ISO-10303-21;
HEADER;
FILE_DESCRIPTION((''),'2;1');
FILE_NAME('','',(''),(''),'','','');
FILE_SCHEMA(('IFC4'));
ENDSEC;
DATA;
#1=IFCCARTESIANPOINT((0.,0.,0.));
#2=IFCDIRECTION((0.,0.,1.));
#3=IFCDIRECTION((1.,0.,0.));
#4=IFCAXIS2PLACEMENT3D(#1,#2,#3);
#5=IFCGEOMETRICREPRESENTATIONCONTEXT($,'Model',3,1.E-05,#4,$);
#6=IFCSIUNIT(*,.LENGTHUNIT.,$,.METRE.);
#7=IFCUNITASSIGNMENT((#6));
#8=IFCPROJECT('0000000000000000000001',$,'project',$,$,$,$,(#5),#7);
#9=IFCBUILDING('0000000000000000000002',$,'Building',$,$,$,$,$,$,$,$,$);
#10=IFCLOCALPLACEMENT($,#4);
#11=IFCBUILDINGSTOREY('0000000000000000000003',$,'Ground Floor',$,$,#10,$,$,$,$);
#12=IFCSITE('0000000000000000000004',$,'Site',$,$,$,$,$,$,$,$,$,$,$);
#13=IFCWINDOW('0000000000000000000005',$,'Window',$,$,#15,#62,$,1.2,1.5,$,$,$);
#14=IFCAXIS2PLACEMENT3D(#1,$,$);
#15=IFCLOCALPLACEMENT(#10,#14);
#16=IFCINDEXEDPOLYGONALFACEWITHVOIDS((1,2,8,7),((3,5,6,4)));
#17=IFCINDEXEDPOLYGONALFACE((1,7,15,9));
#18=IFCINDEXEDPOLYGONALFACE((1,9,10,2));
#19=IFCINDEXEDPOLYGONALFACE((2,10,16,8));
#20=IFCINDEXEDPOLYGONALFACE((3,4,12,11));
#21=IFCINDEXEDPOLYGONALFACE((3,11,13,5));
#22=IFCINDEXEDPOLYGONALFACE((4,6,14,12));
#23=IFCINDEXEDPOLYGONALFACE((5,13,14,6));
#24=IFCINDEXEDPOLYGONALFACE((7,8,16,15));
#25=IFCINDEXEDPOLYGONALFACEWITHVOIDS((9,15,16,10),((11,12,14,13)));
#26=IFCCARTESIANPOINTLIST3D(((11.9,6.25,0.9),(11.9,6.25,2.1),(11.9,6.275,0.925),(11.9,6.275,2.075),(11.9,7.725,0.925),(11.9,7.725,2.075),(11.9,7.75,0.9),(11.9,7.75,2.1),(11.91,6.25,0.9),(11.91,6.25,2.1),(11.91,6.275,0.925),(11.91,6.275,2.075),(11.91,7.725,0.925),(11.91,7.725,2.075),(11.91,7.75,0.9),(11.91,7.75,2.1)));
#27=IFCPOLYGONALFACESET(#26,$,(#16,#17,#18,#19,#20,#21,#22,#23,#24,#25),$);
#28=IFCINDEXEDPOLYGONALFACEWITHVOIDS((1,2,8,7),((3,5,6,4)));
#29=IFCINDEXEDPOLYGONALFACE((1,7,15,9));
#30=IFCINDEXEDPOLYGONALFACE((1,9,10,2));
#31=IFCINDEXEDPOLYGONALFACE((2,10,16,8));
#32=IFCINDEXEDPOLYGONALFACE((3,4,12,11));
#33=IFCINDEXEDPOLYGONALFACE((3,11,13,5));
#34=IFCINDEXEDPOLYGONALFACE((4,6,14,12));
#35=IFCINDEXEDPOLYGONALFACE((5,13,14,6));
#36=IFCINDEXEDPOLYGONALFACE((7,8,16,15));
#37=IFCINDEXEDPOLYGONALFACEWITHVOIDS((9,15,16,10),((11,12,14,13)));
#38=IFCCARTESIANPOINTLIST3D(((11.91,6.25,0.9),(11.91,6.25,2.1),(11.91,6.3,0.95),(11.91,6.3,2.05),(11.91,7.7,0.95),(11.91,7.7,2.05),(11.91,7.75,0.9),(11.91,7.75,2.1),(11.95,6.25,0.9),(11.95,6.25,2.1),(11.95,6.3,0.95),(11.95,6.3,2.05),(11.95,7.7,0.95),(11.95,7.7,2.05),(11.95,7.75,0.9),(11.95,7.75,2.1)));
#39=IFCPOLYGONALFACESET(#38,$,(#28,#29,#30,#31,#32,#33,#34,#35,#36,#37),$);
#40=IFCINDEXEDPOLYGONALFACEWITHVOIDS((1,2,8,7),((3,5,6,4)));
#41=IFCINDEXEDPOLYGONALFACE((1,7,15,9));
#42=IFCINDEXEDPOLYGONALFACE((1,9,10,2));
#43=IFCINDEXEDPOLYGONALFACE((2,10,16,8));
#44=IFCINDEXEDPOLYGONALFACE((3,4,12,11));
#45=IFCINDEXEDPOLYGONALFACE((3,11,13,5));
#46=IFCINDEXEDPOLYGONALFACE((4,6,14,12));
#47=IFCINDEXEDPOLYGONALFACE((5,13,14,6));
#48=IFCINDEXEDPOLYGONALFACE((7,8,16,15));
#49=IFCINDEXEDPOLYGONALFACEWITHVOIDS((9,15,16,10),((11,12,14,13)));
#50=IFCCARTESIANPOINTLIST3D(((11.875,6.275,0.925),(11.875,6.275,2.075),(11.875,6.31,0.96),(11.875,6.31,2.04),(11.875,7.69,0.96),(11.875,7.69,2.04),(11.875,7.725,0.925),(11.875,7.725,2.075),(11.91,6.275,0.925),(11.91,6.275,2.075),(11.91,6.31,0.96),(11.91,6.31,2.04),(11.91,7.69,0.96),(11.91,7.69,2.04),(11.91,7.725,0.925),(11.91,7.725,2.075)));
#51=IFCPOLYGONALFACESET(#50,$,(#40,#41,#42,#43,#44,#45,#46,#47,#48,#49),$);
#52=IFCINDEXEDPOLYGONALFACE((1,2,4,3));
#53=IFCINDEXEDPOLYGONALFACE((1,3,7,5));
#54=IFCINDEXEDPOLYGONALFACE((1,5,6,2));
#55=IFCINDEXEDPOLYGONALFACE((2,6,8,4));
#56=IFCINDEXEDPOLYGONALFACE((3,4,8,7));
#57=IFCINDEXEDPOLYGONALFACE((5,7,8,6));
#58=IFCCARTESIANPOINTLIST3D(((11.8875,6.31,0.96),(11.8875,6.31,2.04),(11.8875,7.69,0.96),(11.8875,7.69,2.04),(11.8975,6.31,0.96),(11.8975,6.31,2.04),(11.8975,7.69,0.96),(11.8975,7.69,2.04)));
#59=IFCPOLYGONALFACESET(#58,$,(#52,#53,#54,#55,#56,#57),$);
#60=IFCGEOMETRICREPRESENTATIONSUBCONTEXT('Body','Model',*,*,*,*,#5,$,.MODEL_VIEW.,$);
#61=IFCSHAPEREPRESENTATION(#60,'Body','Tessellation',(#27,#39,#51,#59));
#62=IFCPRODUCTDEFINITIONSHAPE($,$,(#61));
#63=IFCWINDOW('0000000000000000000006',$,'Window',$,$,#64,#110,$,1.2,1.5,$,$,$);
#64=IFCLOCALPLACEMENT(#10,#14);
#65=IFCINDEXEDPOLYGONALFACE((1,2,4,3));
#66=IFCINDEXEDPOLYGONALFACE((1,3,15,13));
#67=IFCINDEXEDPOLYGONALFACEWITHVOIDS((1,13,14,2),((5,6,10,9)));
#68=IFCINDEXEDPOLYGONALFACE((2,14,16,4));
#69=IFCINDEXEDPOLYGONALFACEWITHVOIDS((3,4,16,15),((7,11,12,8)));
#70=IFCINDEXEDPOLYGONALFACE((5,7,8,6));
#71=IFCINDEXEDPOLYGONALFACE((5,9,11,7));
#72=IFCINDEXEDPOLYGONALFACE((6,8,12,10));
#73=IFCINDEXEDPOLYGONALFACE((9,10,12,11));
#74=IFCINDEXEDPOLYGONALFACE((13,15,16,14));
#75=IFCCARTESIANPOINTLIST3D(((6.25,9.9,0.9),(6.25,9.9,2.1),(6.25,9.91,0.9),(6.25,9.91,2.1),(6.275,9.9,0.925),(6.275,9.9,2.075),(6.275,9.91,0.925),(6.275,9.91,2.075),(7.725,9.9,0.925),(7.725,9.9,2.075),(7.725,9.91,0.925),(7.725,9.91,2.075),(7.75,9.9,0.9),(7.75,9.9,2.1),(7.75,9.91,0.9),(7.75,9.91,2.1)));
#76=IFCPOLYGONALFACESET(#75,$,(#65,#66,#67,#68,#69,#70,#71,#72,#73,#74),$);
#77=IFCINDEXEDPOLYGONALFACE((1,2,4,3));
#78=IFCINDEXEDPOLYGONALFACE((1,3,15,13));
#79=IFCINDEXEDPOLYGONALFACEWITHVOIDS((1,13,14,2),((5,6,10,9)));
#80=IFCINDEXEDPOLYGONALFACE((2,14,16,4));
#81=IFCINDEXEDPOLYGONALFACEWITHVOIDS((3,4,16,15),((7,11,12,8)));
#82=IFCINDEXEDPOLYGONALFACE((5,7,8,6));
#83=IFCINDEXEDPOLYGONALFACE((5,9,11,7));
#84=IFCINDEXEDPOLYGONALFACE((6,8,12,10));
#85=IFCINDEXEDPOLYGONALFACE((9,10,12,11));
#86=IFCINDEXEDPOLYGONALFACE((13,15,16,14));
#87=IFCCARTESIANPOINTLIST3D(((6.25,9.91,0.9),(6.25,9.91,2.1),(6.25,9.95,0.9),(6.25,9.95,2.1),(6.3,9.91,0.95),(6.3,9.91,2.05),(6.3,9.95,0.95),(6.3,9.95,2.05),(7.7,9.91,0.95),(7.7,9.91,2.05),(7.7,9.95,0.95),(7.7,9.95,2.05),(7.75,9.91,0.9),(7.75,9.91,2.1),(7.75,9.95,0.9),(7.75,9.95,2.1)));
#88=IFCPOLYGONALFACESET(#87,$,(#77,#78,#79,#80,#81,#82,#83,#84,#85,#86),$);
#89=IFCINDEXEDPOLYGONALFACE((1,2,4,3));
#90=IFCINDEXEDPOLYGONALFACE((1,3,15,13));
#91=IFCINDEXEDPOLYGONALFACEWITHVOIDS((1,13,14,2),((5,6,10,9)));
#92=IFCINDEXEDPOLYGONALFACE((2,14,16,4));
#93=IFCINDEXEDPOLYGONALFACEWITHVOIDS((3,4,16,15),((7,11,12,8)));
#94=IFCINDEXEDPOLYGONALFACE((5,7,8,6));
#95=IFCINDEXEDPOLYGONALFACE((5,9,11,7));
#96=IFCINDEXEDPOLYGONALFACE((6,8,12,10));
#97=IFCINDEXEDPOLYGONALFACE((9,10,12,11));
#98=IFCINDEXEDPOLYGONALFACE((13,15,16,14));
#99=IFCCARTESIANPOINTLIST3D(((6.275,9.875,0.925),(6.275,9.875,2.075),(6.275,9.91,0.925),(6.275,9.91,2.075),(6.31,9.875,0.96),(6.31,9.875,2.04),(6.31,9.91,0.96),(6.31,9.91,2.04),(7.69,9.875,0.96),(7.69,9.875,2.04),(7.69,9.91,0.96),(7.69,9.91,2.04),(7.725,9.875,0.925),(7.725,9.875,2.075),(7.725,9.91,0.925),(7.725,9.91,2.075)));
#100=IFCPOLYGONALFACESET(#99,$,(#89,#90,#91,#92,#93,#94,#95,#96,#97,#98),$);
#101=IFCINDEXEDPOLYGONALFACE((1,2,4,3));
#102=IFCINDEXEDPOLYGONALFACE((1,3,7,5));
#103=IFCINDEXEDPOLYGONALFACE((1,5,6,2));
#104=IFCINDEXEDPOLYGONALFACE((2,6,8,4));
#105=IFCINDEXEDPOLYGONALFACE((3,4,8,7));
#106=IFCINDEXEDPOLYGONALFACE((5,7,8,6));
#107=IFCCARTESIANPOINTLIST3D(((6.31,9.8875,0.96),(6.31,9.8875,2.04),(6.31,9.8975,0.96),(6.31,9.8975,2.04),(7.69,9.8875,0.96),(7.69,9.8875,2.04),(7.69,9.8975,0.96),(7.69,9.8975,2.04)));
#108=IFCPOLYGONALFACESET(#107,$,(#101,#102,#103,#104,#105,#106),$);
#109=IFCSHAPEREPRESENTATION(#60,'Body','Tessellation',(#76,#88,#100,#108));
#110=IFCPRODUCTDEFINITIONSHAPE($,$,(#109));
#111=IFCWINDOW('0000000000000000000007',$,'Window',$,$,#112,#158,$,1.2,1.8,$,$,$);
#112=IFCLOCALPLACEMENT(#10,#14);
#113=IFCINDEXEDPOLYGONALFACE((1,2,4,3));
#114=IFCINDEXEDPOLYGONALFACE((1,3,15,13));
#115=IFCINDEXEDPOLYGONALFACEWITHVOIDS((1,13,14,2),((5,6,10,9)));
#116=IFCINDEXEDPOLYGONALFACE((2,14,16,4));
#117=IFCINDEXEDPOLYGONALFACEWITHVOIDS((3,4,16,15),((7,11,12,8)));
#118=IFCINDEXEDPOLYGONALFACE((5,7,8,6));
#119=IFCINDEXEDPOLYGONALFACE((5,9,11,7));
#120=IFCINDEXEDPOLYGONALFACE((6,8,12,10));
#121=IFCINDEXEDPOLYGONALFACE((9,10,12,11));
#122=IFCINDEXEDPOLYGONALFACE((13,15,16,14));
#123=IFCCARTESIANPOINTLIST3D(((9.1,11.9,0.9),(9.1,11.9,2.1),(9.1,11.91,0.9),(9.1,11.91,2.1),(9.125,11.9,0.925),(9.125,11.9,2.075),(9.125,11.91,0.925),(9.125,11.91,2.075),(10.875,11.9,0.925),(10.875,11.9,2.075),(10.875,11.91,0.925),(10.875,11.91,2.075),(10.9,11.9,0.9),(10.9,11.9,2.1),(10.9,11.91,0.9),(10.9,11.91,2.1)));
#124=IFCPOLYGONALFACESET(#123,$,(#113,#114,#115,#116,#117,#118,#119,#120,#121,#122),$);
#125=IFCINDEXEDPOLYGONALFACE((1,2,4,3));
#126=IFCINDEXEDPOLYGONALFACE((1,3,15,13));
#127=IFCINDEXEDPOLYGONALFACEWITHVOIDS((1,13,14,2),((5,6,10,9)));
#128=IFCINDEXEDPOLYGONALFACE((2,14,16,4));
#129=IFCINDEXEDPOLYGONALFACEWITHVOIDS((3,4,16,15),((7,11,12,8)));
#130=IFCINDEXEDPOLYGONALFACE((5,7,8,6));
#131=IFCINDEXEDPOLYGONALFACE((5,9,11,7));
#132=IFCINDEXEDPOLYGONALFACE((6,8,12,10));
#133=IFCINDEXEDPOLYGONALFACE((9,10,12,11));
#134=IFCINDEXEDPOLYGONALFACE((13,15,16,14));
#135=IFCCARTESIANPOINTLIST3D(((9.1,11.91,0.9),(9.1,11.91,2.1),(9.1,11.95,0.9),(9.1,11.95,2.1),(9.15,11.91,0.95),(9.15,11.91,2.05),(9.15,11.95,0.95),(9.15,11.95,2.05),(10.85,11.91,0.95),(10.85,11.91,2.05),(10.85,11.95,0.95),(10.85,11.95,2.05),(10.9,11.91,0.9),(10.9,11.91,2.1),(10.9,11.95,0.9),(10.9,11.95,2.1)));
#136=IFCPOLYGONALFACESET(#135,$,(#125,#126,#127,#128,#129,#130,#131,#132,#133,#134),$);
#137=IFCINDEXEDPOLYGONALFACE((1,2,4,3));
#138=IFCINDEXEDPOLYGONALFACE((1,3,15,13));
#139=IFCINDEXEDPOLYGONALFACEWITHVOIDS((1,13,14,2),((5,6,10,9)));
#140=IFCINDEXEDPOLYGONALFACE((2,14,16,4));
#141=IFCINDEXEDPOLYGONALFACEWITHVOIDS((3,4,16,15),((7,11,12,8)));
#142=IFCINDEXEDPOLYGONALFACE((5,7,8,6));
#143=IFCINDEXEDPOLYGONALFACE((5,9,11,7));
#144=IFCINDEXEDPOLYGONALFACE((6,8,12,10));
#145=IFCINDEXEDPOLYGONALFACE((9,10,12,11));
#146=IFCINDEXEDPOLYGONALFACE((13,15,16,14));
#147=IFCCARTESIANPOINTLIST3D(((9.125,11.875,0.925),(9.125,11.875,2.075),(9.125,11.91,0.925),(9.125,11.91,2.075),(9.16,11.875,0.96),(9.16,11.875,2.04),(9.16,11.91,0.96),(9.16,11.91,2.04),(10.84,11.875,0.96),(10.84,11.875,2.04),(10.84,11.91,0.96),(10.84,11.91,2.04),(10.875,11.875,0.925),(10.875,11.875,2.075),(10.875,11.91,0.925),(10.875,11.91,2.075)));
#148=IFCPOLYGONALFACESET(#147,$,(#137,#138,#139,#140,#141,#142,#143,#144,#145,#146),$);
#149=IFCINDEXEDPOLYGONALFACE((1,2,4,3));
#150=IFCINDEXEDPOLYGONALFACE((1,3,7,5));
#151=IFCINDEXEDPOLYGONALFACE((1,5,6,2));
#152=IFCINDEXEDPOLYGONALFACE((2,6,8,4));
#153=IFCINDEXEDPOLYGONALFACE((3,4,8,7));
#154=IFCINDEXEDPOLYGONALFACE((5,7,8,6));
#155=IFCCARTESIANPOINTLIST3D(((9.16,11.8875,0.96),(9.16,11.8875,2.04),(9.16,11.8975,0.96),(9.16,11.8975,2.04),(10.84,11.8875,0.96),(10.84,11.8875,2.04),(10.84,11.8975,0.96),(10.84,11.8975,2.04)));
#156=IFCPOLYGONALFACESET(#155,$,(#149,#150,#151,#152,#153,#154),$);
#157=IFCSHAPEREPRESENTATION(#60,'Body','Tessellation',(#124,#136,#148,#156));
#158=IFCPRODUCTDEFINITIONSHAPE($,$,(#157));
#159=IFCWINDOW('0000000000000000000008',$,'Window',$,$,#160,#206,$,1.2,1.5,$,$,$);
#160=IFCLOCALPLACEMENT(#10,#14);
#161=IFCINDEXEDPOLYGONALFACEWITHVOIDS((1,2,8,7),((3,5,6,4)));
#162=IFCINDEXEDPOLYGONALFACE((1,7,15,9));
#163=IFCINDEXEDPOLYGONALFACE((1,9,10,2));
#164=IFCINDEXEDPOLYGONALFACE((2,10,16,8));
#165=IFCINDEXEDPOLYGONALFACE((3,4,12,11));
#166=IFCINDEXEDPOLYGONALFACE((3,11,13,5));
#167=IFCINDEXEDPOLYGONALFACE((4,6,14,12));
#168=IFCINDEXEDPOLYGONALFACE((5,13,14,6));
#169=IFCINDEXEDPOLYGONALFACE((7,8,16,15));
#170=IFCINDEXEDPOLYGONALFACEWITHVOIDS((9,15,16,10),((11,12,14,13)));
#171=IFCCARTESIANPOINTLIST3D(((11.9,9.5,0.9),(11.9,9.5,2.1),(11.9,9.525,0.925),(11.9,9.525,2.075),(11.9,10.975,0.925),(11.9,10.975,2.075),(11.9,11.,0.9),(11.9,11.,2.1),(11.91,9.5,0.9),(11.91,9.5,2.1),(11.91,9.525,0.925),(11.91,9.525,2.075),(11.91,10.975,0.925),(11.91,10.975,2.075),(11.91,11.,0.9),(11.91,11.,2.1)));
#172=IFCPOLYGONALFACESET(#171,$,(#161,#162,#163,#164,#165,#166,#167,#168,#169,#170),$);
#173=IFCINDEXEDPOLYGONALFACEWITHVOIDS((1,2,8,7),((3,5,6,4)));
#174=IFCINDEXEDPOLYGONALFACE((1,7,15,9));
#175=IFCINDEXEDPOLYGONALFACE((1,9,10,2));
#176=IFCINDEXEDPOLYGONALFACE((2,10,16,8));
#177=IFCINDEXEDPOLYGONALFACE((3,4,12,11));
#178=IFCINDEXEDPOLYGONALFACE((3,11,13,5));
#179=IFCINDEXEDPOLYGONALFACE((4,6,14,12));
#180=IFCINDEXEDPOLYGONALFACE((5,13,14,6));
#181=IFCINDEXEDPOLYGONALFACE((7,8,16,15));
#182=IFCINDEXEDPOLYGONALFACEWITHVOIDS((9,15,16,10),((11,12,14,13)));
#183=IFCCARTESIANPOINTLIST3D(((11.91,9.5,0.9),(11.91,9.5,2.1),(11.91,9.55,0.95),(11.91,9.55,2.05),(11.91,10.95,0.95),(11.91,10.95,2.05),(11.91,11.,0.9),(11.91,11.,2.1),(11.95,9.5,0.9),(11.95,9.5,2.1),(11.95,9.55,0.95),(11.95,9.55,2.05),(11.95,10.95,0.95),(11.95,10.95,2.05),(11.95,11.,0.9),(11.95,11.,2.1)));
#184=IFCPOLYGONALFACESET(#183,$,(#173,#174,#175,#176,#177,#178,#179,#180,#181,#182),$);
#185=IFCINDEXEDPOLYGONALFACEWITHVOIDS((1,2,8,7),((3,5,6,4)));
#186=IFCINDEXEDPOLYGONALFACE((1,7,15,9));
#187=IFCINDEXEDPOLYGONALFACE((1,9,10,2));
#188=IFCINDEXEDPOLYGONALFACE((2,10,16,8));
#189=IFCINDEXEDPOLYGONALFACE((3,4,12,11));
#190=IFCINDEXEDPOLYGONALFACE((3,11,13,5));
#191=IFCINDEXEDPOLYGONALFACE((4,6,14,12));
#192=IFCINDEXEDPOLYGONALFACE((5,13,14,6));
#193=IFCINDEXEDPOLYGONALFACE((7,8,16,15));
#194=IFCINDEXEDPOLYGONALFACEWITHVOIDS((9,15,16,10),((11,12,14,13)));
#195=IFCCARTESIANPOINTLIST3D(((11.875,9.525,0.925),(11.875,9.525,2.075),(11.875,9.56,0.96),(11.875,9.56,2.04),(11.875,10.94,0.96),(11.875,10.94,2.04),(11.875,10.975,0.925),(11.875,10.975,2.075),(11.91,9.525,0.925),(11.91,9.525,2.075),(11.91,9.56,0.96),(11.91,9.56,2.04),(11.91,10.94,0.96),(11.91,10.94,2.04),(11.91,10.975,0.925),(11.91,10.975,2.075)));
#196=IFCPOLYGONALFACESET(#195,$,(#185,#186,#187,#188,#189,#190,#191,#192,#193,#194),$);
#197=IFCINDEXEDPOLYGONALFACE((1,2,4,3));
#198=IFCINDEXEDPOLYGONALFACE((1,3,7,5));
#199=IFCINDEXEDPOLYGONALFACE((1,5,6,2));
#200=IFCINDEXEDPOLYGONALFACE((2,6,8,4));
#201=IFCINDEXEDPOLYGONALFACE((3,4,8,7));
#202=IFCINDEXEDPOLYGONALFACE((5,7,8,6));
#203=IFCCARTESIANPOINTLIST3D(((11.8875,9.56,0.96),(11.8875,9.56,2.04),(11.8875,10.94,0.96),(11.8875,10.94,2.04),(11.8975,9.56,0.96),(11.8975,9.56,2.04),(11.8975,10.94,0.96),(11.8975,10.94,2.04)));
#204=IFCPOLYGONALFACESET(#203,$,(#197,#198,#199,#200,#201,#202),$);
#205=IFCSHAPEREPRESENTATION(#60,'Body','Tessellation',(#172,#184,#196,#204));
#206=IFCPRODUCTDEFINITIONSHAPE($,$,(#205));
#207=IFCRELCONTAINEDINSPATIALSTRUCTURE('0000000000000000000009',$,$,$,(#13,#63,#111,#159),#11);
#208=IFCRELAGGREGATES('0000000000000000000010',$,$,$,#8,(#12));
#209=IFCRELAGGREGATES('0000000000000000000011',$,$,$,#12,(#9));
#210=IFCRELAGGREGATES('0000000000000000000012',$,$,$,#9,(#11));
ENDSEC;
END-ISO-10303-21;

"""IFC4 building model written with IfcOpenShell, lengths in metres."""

from ifc_helpers import new_model, si_unit, frame, origin_with_axes, place, context, subcontext, project, spatial, line, indexed_curve, outline, extrude, element, save


model = new_model("IFC4")

# Units and contexts
model_context = context("Model", 3, precision=1e-05, world=origin_with_axes())
body_context = subcontext(model_context, "Body", "Model", "MODEL_VIEW")
ifc_project = project(units=[si_unit("LENGTHUNIT", "METRE")], contexts=[model_context])

# Site, building, storey
site = spatial("IfcSite", under=ifc_project, Name="Site")
building = spatial("IfcBuilding", under=site, Name="Building")
storey_placement = place(None, origin_with_axes())
storey = spatial("IfcBuildingStorey", under=building, at=storey_placement, Name="Ground Floor")

# Windows
for number, where, z_axis, x_axis, name in (
    (1, (12.0, 6.25, 0.9), (0.0, 0.0, 1.0), (0.0, 1.0, 0.0), "Window"),
    (2, (7.75, 10.0, 0.9), (0.0, 0.0, 1.0), (-1.0, 0.0, 0.0), "Window"),
):
    element("IfcWindow", number, at=place(storey_placement, frame(where, z_axis=z_axis, x_axis=x_axis)), inside=storey, Name=name, OverallHeight=1.2, OverallWidth=1.5, context=body_context, shape_type="SweptSolid", body=[
        extrude(outline(indexed_curve([(0.0, 0.0), (1.5, 0.0), (1.5, 1.2), (0.0, 1.2)], segments=[line(1, 2, 3, 4, 1)]), holes=[indexed_curve([(0.025, 0.025), (1.475, 0.025), (1.475, 1.175), (0.025, 1.175)], segments=[line(1, 2, 3, 4, 1)])]), frame((0.0, 0.09, 0.0), z_axis=(0.0, -1.0, 0.0), x_axis=(1.0, 0.0, 0.0)), (0.0, 0.0, -1.0), 0.01),
        extrude(outline(indexed_curve([(0.0, 0.0), (1.5, 0.0), (1.5, 1.2), (0.0, 1.2)], segments=[line(1, 2, 3, 4, 1)]), holes=[indexed_curve([(0.05, 0.05), (1.45, 0.05), (1.45, 1.15), (0.05, 1.15)], segments=[line(1, 2, 3, 4, 1)])]), frame((0.0, 0.05, 0.0), z_axis=(0.0, -1.0, 0.0), x_axis=(1.0, 0.0, 0.0)), (0.0, 0.0, -1.0), 0.04),
        extrude(outline(indexed_curve([(0.0, 0.0), (1.45, 0.0), (1.45, 1.15), (0.0, 1.15)], segments=[line(1, 2, 3, 4, 1)]), holes=[indexed_curve([(0.035, 0.035), (1.415, 0.035), (1.415, 1.115), (0.035, 1.115)], segments=[line(1, 2, 3, 4, 1)])]), frame((0.025, 0.09, 0.025), z_axis=(0.0, -1.0, 0.0), x_axis=(1.0, 0.0, 0.0)), (0.0, 0.0, -1.0), 0.035),
        extrude(outline(indexed_curve([(0.035, 0.035), (1.415, 0.035), (1.415, 1.115), (0.035, 1.115)], segments=[line(1, 2, 3, 4, 1)])), frame((0.025, 0.1025, 0.025), z_axis=(0.0, -1.0, 0.0), x_axis=(1.0, 0.0, 0.0)), (0.0, 0.0, -1.0), 0.01),
    ])
window_1_placement = place(storey_placement, frame((10.9, 12.0, 0.9), z_axis=(0.0, 0.0, 1.0), x_axis=(-1.0, 0.0, 0.0)))
element("IfcWindow", 3, at=window_1_placement, inside=storey, Name="Window", OverallHeight=1.2, OverallWidth=1.8, context=body_context, shape_type="SweptSolid", body=[
    extrude(outline(indexed_curve([(0.0, 0.0), (1.8, 0.0), (1.8, 1.2), (0.0, 1.2)], segments=[line(1, 2, 3, 4, 1)]), holes=[indexed_curve([(0.025, 0.025), (1.775, 0.025), (1.775, 1.175), (0.025, 1.175)], segments=[line(1, 2, 3, 4, 1)])]), frame((0.0, 0.09, 0.0), z_axis=(0.0, -1.0, 0.0), x_axis=(1.0, 0.0, 0.0)), (0.0, 0.0, -1.0), 0.01),
    extrude(outline(indexed_curve([(0.0, 0.0), (1.8, 0.0), (1.8, 1.2), (0.0, 1.2)], segments=[line(1, 2, 3, 4, 1)]), holes=[indexed_curve([(0.05, 0.05), (1.75, 0.05), (1.75, 1.15), (0.05, 1.15)], segments=[line(1, 2, 3, 4, 1)])]), frame((0.0, 0.05, 0.0), z_axis=(0.0, -1.0, 0.0), x_axis=(1.0, 0.0, 0.0)), (0.0, 0.0, -1.0), 0.04),
    extrude(outline(indexed_curve([(0.0, 0.0), (1.75, 0.0), (1.75, 1.15), (0.0, 1.15)], segments=[line(1, 2, 3, 4, 1)]), holes=[indexed_curve([(0.035, 0.035), (1.715, 0.035), (1.715, 1.115), (0.035, 1.115)], segments=[line(1, 2, 3, 4, 1)])]), frame((0.025, 0.09, 0.025), z_axis=(0.0, -1.0, 0.0), x_axis=(1.0, 0.0, 0.0)), (0.0, 0.0, -1.0), 0.035),
    extrude(outline(indexed_curve([(0.035, 0.035), (1.715, 0.035), (1.715, 1.115), (0.035, 1.115)], segments=[line(1, 2, 3, 4, 1)])), frame((0.025, 0.1025, 0.025), z_axis=(0.0, -1.0, 0.0), x_axis=(1.0, 0.0, 0.0)), (0.0, 0.0, -1.0), 0.01),
])
window_2_placement = place(storey_placement, frame((12.0, 9.5, 0.9), z_axis=(0.0, 0.0, 1.0), x_axis=(0.0, 1.0, 0.0)))
element("IfcWindow", 4, at=window_2_placement, inside=storey, Name="Window", OverallHeight=1.2, OverallWidth=1.5, context=body_context, shape_type="SweptSolid", body=[
    extrude(outline(indexed_curve([(0.0, 0.0), (1.5, 0.0), (1.5, 1.2), (0.0, 1.2)], segments=[line(1, 2, 3, 4, 1)]), holes=[indexed_curve([(0.025, 0.025), (1.475, 0.025), (1.475, 1.175), (0.025, 1.175)], segments=[line(1, 2, 3, 4, 1)])]), frame((0.0, 0.09, 0.0), z_axis=(0.0, -1.0, 0.0), x_axis=(1.0, 0.0, 0.0)), (0.0, 0.0, -1.0), 0.01),
    extrude(outline(indexed_curve([(0.0, 0.0), (1.5, 0.0), (1.5, 1.2), (0.0, 1.2)], segments=[line(1, 2, 3, 4, 1)]), holes=[indexed_curve([(0.05, 0.05), (1.45, 0.05), (1.45, 1.15), (0.05, 1.15)], segments=[line(1, 2, 3, 4, 1)])]), frame((0.0, 0.05, 0.0), z_axis=(0.0, -1.0, 0.0), x_axis=(1.0, 0.0, 0.0)), (0.0, 0.0, -1.0), 0.04),
    extrude(outline(indexed_curve([(0.0, 0.0), (1.45, 0.0), (1.45, 1.15), (0.0, 1.15)], segments=[line(1, 2, 3, 4, 1)]), holes=[indexed_curve([(0.035, 0.035), (1.415, 0.035), (1.415, 1.115), (0.035, 1.115)], segments=[line(1, 2, 3, 4, 1)])]), frame((0.025, 0.09, 0.025), z_axis=(0.0, -1.0, 0.0), x_axis=(1.0, 0.0, 0.0)), (0.0, 0.0, -1.0), 0.035),
    extrude(outline(indexed_curve([(0.035, 0.035), (1.415, 0.035), (1.415, 1.115), (0.035, 1.115)], segments=[line(1, 2, 3, 4, 1)])), frame((0.025, 0.1025, 0.025), z_axis=(0.0, -1.0, 0.0), x_axis=(1.0, 0.0, 0.0)), (0.0, 0.0, -1.0), 0.01),
])

save(model, "model.ifc")
